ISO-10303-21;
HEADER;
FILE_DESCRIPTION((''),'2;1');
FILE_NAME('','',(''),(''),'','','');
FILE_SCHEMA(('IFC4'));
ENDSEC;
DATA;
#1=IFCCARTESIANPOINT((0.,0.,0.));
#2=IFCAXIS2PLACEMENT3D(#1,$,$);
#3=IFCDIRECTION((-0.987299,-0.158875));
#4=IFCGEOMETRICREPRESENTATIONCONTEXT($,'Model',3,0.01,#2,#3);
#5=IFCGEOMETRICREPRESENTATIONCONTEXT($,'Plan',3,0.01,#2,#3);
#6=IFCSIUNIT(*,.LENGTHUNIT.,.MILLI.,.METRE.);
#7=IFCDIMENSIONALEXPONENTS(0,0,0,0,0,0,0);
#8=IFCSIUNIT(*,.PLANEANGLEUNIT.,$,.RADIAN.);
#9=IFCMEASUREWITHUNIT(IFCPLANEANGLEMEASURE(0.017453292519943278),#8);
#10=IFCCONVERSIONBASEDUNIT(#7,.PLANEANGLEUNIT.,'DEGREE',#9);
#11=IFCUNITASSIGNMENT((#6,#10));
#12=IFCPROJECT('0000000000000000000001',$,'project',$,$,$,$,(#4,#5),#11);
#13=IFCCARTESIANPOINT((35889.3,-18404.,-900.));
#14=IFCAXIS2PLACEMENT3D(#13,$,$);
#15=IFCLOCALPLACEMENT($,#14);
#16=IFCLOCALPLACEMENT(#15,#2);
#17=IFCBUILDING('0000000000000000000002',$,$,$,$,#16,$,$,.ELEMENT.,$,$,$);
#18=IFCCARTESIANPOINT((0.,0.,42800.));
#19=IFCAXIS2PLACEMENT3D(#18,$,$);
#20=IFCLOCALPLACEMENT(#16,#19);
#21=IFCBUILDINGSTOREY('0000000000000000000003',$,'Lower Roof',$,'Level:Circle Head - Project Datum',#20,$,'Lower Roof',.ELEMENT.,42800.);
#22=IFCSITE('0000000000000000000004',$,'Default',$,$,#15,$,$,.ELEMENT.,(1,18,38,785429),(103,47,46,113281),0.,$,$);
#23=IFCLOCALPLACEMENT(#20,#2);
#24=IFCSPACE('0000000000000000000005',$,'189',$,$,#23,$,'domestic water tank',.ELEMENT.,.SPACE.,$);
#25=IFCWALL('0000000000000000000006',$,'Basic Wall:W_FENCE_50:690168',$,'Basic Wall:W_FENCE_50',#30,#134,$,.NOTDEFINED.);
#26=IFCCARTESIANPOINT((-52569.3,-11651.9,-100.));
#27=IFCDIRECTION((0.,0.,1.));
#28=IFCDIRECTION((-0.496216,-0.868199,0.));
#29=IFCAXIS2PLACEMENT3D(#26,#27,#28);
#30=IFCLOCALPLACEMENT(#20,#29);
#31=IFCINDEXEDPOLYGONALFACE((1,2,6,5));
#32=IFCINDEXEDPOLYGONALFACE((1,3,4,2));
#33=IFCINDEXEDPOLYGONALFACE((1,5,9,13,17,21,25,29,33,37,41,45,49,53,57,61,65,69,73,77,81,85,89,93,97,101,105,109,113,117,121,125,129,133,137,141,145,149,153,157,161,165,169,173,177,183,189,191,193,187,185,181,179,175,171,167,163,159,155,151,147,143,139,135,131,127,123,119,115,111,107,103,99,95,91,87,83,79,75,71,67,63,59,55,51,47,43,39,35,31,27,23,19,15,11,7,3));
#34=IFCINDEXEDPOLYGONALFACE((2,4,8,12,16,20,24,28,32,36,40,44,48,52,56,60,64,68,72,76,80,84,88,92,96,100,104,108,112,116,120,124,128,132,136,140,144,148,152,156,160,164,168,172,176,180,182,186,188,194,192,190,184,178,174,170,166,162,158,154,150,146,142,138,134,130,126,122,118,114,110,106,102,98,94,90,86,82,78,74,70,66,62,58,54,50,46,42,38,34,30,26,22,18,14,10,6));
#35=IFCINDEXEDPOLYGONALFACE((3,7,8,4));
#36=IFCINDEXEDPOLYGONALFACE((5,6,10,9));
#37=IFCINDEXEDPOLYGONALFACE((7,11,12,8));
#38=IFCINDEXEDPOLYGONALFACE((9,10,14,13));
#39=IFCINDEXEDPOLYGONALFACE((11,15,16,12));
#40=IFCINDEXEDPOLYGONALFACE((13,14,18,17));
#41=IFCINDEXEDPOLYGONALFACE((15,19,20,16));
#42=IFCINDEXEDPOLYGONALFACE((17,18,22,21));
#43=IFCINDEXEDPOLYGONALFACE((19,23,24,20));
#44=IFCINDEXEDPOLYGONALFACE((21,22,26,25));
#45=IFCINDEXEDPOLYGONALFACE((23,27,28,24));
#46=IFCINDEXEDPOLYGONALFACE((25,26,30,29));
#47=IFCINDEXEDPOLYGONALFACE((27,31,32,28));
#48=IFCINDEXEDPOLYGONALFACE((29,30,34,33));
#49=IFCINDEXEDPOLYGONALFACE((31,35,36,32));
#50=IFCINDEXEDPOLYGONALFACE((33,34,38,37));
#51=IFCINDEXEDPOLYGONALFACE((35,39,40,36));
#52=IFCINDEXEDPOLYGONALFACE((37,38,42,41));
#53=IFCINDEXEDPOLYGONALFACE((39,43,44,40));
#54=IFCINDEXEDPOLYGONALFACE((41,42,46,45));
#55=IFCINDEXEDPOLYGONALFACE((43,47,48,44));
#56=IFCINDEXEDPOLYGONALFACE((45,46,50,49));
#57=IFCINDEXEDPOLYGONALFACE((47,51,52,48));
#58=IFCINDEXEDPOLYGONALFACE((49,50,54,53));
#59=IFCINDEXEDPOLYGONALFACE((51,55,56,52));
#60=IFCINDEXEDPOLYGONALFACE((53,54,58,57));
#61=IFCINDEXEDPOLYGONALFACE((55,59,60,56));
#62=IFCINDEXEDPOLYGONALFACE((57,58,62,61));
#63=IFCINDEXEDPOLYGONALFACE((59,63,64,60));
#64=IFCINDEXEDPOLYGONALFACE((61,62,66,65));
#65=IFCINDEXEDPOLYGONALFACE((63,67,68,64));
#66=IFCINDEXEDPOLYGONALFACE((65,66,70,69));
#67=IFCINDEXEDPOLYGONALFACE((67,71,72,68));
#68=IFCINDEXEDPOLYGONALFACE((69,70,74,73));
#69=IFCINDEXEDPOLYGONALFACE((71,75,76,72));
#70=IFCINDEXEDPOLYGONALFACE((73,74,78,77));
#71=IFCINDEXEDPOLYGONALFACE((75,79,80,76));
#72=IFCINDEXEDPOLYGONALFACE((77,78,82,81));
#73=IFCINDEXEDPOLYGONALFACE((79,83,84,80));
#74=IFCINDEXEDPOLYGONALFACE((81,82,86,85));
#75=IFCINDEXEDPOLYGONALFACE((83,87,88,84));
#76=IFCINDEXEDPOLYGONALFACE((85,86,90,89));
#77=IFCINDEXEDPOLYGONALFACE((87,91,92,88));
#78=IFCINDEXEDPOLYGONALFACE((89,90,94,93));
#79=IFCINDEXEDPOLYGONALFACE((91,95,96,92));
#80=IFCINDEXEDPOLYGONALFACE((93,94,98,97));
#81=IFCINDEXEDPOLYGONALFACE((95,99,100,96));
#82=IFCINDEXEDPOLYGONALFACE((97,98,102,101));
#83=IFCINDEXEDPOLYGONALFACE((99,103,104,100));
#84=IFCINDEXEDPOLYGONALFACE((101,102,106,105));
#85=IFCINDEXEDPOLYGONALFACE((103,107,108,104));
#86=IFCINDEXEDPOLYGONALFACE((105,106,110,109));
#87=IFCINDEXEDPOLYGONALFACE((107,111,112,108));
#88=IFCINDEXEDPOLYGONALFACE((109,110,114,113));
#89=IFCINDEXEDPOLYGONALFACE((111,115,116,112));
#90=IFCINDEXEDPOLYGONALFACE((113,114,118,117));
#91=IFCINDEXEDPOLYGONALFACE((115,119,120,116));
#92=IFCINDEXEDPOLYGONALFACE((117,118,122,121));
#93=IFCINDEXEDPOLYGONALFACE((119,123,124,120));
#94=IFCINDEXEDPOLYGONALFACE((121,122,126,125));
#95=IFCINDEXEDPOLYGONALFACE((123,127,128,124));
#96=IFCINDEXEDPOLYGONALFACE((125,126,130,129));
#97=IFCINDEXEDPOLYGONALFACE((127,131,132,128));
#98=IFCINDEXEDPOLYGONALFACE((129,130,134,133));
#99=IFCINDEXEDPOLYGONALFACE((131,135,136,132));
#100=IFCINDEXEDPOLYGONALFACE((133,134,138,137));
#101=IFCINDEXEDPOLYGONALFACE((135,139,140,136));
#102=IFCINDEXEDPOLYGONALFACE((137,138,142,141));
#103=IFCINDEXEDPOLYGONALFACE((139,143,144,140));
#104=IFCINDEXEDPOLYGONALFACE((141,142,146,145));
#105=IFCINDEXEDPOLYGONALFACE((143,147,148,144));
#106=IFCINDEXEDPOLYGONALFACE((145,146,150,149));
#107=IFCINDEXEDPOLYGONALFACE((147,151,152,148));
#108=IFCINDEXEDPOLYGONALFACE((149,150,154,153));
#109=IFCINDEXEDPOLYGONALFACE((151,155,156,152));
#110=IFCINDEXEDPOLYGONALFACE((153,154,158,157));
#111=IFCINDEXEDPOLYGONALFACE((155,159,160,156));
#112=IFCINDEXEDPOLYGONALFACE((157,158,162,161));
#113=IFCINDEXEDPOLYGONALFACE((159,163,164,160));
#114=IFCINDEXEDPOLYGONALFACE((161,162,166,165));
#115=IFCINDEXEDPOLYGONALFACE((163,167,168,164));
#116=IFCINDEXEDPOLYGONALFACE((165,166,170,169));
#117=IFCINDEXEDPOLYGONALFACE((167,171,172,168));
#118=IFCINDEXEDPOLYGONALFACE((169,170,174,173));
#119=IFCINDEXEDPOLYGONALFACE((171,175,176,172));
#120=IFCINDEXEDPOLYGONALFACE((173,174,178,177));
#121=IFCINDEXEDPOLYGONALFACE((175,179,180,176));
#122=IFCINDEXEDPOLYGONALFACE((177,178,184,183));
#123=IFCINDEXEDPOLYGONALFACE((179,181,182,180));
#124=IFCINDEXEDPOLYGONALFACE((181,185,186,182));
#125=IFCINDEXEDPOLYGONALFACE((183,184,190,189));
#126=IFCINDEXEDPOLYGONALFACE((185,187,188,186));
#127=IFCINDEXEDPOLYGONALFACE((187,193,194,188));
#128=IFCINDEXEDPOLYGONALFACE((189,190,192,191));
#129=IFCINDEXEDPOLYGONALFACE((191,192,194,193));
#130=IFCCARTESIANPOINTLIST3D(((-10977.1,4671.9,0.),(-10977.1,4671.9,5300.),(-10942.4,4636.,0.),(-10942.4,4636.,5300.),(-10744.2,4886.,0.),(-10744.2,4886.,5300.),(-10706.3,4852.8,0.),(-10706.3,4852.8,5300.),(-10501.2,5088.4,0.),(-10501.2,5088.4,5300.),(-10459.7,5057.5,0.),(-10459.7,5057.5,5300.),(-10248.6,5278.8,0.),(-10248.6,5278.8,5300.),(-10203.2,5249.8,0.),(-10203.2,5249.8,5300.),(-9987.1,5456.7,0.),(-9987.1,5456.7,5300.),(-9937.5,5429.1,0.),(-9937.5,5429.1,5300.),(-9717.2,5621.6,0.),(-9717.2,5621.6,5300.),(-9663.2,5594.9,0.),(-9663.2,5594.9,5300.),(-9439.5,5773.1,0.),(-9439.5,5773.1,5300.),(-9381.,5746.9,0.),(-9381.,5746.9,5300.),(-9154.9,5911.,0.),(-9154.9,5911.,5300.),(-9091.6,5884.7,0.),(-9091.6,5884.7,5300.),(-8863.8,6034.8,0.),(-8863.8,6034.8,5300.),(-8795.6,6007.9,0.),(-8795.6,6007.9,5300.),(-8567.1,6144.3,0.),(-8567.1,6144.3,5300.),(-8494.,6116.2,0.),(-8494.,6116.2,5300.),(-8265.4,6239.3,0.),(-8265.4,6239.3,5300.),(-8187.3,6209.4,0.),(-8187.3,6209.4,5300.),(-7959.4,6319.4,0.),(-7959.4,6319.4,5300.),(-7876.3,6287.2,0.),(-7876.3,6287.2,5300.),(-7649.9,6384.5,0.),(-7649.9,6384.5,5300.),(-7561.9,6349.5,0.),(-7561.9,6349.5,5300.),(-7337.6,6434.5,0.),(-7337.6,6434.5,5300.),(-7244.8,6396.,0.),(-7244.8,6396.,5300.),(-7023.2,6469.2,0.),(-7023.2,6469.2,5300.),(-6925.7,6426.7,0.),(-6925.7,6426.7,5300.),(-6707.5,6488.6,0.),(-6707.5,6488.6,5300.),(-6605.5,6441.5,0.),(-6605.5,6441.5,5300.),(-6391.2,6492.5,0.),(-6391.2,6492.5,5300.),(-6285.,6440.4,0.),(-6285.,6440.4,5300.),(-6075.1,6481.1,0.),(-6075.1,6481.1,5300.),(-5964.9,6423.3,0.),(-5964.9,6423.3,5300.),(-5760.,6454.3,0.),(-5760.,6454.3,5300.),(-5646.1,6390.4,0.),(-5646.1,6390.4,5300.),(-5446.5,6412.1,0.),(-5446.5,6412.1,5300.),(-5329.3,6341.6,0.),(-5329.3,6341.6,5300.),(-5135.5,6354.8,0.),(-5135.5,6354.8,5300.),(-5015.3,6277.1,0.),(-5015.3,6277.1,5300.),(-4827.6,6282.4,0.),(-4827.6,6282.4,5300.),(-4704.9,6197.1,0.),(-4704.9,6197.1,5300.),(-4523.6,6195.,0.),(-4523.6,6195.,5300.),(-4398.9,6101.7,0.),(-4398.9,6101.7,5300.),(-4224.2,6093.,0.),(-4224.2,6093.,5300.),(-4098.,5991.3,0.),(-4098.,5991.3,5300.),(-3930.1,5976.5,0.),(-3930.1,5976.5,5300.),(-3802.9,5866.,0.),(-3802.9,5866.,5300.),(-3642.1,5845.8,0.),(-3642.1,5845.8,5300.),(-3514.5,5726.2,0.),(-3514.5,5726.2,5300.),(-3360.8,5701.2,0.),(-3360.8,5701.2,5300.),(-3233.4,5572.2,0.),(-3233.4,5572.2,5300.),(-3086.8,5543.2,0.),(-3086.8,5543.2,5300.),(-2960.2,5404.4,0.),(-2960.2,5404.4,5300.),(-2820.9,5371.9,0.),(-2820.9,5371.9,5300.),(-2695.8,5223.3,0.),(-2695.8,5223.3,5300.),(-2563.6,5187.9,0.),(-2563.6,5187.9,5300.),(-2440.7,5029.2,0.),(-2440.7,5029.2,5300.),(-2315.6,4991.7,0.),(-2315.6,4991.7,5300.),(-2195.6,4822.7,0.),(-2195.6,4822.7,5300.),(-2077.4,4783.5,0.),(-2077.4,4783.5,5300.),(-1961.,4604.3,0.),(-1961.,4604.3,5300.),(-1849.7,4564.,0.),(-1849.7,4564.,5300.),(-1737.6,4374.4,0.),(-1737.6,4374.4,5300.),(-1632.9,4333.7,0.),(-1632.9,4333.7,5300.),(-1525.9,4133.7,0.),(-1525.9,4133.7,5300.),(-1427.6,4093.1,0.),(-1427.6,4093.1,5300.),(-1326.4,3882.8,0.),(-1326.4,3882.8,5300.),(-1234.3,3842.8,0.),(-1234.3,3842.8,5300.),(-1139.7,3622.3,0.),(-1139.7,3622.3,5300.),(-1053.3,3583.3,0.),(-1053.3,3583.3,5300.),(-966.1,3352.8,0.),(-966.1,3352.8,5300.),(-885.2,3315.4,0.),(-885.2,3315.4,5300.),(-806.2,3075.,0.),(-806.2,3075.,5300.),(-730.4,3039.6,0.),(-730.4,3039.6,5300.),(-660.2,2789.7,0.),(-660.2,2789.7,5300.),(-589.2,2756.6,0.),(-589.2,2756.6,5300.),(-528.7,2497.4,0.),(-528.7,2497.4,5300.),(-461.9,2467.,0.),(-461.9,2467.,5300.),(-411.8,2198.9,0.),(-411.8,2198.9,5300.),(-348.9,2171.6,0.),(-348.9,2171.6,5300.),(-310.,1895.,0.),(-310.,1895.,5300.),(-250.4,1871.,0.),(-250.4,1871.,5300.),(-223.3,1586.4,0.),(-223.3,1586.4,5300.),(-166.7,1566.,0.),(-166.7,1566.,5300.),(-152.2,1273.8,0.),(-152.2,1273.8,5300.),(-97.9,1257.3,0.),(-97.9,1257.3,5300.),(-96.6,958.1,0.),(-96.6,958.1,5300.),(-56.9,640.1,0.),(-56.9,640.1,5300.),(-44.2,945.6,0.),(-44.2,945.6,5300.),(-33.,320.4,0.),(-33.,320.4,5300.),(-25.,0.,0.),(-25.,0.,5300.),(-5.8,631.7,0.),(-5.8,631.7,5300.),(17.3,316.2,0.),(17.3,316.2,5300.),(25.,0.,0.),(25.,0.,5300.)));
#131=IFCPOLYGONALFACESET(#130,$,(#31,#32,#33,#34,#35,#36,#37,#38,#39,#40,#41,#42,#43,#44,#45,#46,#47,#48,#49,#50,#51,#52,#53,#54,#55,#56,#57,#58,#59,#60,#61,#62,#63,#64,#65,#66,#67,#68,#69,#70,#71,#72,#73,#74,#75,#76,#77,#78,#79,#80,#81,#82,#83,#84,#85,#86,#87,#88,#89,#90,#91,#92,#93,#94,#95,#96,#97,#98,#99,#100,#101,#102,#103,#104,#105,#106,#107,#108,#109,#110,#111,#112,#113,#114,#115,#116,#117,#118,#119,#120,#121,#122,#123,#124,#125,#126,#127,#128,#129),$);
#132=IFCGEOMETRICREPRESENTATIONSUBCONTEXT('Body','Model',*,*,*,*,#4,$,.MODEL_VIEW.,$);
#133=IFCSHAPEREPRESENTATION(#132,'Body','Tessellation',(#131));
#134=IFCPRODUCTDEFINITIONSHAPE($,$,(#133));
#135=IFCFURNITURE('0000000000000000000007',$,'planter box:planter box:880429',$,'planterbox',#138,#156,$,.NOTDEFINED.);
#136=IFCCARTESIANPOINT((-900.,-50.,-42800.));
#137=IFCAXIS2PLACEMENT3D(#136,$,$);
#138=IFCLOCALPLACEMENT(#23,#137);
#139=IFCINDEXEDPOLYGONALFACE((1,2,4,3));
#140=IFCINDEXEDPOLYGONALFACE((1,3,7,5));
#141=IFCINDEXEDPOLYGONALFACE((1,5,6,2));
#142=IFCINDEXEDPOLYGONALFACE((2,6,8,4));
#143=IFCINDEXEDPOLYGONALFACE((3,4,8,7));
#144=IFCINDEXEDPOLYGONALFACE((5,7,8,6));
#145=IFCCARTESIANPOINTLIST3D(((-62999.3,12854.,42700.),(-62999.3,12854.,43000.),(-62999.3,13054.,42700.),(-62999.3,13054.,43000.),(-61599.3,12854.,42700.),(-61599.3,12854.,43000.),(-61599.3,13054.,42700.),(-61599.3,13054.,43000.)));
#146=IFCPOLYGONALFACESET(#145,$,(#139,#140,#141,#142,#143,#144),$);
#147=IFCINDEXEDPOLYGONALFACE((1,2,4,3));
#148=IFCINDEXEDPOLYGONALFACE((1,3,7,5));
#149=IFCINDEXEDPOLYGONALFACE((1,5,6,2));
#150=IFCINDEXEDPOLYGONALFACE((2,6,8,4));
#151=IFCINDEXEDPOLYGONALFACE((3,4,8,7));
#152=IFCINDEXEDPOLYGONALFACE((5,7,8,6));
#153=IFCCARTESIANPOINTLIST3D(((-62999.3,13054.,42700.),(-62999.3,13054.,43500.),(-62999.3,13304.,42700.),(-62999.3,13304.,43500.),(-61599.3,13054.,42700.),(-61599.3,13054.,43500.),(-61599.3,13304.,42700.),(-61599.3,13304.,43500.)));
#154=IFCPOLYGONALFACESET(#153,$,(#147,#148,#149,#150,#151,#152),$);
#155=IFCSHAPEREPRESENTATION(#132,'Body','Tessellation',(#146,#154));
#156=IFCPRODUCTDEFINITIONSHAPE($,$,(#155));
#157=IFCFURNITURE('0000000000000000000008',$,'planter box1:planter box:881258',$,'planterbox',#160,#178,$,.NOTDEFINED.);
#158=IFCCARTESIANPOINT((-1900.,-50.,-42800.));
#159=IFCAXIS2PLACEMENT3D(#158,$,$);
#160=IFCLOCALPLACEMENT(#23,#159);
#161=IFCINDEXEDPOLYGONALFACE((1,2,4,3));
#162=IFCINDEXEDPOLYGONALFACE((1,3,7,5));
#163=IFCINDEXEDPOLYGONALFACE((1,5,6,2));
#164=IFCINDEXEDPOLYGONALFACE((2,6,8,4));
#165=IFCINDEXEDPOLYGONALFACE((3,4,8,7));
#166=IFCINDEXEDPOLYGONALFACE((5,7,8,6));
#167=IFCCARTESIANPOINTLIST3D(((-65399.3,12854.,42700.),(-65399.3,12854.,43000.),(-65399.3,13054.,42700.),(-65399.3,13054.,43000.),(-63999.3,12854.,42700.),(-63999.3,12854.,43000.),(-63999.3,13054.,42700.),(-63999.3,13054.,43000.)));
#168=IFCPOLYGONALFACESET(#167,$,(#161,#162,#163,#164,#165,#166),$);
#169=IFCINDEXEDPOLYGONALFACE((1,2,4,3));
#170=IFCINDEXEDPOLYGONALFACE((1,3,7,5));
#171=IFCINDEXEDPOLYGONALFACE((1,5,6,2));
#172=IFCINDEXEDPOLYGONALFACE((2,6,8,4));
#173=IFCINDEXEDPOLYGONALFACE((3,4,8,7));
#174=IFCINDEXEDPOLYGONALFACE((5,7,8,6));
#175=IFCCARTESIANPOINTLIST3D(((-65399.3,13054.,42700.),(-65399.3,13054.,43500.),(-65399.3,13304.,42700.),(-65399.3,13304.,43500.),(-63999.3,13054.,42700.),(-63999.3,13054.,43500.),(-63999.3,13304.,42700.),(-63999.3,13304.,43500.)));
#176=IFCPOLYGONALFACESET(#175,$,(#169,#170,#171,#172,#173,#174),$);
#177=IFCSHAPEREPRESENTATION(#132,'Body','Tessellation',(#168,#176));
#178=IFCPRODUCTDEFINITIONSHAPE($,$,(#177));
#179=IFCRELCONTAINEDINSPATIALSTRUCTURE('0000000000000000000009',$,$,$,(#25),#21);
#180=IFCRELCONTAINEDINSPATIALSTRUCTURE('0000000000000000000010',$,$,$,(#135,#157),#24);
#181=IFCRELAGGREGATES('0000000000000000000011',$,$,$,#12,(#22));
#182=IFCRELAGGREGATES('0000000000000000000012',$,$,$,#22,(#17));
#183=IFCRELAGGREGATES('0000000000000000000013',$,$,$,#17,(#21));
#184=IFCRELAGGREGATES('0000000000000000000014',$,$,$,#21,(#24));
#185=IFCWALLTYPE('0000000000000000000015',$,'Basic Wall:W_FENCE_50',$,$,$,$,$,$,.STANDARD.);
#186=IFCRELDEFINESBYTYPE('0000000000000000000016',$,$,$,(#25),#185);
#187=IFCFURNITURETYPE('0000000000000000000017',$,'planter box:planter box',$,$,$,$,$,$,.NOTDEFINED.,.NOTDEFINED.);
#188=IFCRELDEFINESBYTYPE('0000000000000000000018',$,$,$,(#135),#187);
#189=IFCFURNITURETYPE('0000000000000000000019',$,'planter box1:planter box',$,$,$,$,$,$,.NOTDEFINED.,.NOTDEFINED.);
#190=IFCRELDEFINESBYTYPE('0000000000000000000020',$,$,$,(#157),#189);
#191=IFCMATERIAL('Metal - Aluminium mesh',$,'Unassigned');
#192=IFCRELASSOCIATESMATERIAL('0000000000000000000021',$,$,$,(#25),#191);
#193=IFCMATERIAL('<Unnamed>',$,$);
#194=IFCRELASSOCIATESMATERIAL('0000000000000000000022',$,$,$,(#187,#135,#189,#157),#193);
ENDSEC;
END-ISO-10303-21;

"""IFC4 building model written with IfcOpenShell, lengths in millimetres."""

from ifc_helpers import new_model, entity, si_unit, converted_unit, direction, frame, origin, place, context, subcontext, project, spatial, line, arc, indexed_curve, outline, extrude, source, transform, mapped, material, type_object, type_shapes, element, save


model = new_model("IFC4")

# Units and contexts
model_context = context("Model", 3, precision=0.01, world=origin(), true_north=direction((-0.987299, -0.158875)))
plan_context = context("Plan", 3, precision=0.01, world=origin(), true_north=direction((-0.987299, -0.158875)))
body_context = subcontext(model_context, "Body", "Model", "MODEL_VIEW")
ifc_project = project(units=[si_unit("LENGTHUNIT", "METRE", prefix="MILLI"), converted_unit("PLANEANGLEUNIT", "DEGREE", entity("IfcPlaneAngleMeasure", 0.017453292519943278), si_unit("PLANEANGLEUNIT", "RADIAN"), dimensions=[0, 0, 0, 0, 0, 0, 0])], contexts=[model_context, plan_context])

# Site, building, storey
site_placement = place(None, frame((35889.3, -18404.0, -900.0)))
site = spatial("IfcSite", under=ifc_project, at=site_placement, Name="Default", CompositionType="ELEMENT", RefLatitude=(1, 18, 38, 785429), RefLongitude=(103, 47, 46, 113281), RefElevation=0.0)
building_placement = place(site_placement, origin())
building = spatial("IfcBuilding", under=site, at=building_placement, CompositionType="ELEMENT")
storey_placement = place(building_placement, frame((0.0, 0.0, 42800.0)))
storey = spatial("IfcBuildingStorey", under=building, at=storey_placement, Name="Lower Roof", ObjectType="Level:Circle Head - Project Datum", LongName="Lower Roof", CompositionType="ELEMENT", Elevation=42800.0)

# Wall
ifc_material_1 = material(Name="Metal - Aluminium mesh", Category="Unassigned")
wall_type_1 = type_object("IfcWallType", Name="Basic Wall:W_FENCE_50", PredefinedType="STANDARD")
wall_1_placement = place(storey_placement, frame((-52569.3, -11651.9, -100.0), z_axis=(0.0, 0.0, 1.0), x_axis=(-0.496216, -0.868199, 0.0)))
element("IfcWall", 1, at=wall_1_placement, inside=storey, type_object=wall_type_1, material=ifc_material_1, Name="Basic Wall:W_FENCE_50:690168", ObjectType="Basic Wall:W_FENCE_50", PredefinedType="NOTDEFINED", context=body_context, shape_type="SweptSolid", body=[
    extrude(outline(indexed_curve([(-10942.4, 4636.0), (-3949.7, 5930.5), (-25.0, 0.0), (25.0, 0.0), (-3930.1, 5976.5), (-10977.1, 4671.9)], segments=[arc(1, 2, 3), line(3, 4), arc(4, 5, 6), line(6, 1)], self_intersect=False)), origin(), (0.0, 0.0, 1.0), 5300.0),
])

# Shared definitions
ifc_material_2 = material(Name="<Unnamed>")

# Shared definitions
space_1_placement = place(storey_placement, origin())
space_1 = spatial("IfcSpace", under=storey, at=space_1_placement, Name="189", LongName="domestic water tank", CompositionType="ELEMENT", PredefinedType="SPACE")

# Furniture
furniture_type_1 = type_object("IfcFurnitureType", Name="planter box:planter box", AssemblyPlace="NOTDEFINED", PredefinedType="NOTDEFINED", material=ifc_material_2)
shared_shape_1 = source(origin(), body_context, "Body", "SweptSolid", [
    extrude(outline(indexed_curve([(-100.0, -700.0), (100.0, -700.0), (100.0, 700.0), (-100.0, 700.0), (-100.0, -700.0)], self_intersect=False)), frame((-62299.3, 12954.0, 42700.0), z_axis=(0.0, 0.0, 1.0), x_axis=(0.0, -1.0, 0.0)), (0.0, 0.0, 1.0), 300.0),
    extrude(outline(indexed_curve([(-125.0, -700.0), (125.0, -700.0), (125.0, 700.0), (-125.0, 700.0), (-125.0, -700.0)], self_intersect=False)), frame((-62299.3, 13179.0, 42700.0), z_axis=(0.0, 0.0, 1.0), x_axis=(0.0, -1.0, 0.0)), (0.0, 0.0, 1.0), 800.0),
])
type_shapes(furniture_type_1, [shared_shape_1])
furniture_1_placement = place(space_1_placement, frame((-900.0, -50.0, -42800.0)))
element("IfcFurniture", 2, at=furniture_1_placement, inside=space_1, type_object=furniture_type_1, material=ifc_material_2, Name="planter box:planter box:880429", ObjectType="planterbox", PredefinedType="NOTDEFINED", context=body_context, shape_type="MappedRepresentation", body=[
    mapped(shared_shape_1, transform((0.0, 0.0, 0.0), scale=1.0)),
])
furniture_type_2 = type_object("IfcFurnitureType", Name="planter box1:planter box", AssemblyPlace="NOTDEFINED", PredefinedType="NOTDEFINED", material=ifc_material_2)
shared_shape_2 = source(origin(), body_context, "Body", "SweptSolid", [
    extrude(outline(indexed_curve([(-100.0, -700.0), (100.0, -700.0), (100.0, 700.0), (-100.0, 700.0), (-100.0, -700.0)], self_intersect=False)), frame((-64699.3, 12954.0, 42700.0), z_axis=(0.0, 0.0, 1.0), x_axis=(0.0, -1.0, 0.0)), (0.0, 0.0, 1.0), 300.0),
    extrude(outline(indexed_curve([(-125.0, -700.0), (125.0, -700.0), (125.0, 700.0), (-125.0, 700.0), (-125.0, -700.0)], self_intersect=False)), frame((-64699.3, 13179.0, 42700.0), z_axis=(0.0, 0.0, 1.0), x_axis=(0.0, -1.0, 0.0)), (0.0, 0.0, 1.0), 800.0),
])
type_shapes(furniture_type_2, [shared_shape_2])
furniture_2_placement = place(space_1_placement, frame((-1900.0, -50.0, -42800.0)))
element("IfcFurniture", 3, at=furniture_2_placement, inside=space_1, type_object=furniture_type_2, material=ifc_material_2, Name="planter box1:planter box:881258", ObjectType="planterbox", PredefinedType="NOTDEFINED", context=body_context, shape_type="MappedRepresentation", body=[
    mapped(shared_shape_2, transform((0.0, 0.0, 0.0), scale=1.0)),
])

save(model, "model.ifc")
